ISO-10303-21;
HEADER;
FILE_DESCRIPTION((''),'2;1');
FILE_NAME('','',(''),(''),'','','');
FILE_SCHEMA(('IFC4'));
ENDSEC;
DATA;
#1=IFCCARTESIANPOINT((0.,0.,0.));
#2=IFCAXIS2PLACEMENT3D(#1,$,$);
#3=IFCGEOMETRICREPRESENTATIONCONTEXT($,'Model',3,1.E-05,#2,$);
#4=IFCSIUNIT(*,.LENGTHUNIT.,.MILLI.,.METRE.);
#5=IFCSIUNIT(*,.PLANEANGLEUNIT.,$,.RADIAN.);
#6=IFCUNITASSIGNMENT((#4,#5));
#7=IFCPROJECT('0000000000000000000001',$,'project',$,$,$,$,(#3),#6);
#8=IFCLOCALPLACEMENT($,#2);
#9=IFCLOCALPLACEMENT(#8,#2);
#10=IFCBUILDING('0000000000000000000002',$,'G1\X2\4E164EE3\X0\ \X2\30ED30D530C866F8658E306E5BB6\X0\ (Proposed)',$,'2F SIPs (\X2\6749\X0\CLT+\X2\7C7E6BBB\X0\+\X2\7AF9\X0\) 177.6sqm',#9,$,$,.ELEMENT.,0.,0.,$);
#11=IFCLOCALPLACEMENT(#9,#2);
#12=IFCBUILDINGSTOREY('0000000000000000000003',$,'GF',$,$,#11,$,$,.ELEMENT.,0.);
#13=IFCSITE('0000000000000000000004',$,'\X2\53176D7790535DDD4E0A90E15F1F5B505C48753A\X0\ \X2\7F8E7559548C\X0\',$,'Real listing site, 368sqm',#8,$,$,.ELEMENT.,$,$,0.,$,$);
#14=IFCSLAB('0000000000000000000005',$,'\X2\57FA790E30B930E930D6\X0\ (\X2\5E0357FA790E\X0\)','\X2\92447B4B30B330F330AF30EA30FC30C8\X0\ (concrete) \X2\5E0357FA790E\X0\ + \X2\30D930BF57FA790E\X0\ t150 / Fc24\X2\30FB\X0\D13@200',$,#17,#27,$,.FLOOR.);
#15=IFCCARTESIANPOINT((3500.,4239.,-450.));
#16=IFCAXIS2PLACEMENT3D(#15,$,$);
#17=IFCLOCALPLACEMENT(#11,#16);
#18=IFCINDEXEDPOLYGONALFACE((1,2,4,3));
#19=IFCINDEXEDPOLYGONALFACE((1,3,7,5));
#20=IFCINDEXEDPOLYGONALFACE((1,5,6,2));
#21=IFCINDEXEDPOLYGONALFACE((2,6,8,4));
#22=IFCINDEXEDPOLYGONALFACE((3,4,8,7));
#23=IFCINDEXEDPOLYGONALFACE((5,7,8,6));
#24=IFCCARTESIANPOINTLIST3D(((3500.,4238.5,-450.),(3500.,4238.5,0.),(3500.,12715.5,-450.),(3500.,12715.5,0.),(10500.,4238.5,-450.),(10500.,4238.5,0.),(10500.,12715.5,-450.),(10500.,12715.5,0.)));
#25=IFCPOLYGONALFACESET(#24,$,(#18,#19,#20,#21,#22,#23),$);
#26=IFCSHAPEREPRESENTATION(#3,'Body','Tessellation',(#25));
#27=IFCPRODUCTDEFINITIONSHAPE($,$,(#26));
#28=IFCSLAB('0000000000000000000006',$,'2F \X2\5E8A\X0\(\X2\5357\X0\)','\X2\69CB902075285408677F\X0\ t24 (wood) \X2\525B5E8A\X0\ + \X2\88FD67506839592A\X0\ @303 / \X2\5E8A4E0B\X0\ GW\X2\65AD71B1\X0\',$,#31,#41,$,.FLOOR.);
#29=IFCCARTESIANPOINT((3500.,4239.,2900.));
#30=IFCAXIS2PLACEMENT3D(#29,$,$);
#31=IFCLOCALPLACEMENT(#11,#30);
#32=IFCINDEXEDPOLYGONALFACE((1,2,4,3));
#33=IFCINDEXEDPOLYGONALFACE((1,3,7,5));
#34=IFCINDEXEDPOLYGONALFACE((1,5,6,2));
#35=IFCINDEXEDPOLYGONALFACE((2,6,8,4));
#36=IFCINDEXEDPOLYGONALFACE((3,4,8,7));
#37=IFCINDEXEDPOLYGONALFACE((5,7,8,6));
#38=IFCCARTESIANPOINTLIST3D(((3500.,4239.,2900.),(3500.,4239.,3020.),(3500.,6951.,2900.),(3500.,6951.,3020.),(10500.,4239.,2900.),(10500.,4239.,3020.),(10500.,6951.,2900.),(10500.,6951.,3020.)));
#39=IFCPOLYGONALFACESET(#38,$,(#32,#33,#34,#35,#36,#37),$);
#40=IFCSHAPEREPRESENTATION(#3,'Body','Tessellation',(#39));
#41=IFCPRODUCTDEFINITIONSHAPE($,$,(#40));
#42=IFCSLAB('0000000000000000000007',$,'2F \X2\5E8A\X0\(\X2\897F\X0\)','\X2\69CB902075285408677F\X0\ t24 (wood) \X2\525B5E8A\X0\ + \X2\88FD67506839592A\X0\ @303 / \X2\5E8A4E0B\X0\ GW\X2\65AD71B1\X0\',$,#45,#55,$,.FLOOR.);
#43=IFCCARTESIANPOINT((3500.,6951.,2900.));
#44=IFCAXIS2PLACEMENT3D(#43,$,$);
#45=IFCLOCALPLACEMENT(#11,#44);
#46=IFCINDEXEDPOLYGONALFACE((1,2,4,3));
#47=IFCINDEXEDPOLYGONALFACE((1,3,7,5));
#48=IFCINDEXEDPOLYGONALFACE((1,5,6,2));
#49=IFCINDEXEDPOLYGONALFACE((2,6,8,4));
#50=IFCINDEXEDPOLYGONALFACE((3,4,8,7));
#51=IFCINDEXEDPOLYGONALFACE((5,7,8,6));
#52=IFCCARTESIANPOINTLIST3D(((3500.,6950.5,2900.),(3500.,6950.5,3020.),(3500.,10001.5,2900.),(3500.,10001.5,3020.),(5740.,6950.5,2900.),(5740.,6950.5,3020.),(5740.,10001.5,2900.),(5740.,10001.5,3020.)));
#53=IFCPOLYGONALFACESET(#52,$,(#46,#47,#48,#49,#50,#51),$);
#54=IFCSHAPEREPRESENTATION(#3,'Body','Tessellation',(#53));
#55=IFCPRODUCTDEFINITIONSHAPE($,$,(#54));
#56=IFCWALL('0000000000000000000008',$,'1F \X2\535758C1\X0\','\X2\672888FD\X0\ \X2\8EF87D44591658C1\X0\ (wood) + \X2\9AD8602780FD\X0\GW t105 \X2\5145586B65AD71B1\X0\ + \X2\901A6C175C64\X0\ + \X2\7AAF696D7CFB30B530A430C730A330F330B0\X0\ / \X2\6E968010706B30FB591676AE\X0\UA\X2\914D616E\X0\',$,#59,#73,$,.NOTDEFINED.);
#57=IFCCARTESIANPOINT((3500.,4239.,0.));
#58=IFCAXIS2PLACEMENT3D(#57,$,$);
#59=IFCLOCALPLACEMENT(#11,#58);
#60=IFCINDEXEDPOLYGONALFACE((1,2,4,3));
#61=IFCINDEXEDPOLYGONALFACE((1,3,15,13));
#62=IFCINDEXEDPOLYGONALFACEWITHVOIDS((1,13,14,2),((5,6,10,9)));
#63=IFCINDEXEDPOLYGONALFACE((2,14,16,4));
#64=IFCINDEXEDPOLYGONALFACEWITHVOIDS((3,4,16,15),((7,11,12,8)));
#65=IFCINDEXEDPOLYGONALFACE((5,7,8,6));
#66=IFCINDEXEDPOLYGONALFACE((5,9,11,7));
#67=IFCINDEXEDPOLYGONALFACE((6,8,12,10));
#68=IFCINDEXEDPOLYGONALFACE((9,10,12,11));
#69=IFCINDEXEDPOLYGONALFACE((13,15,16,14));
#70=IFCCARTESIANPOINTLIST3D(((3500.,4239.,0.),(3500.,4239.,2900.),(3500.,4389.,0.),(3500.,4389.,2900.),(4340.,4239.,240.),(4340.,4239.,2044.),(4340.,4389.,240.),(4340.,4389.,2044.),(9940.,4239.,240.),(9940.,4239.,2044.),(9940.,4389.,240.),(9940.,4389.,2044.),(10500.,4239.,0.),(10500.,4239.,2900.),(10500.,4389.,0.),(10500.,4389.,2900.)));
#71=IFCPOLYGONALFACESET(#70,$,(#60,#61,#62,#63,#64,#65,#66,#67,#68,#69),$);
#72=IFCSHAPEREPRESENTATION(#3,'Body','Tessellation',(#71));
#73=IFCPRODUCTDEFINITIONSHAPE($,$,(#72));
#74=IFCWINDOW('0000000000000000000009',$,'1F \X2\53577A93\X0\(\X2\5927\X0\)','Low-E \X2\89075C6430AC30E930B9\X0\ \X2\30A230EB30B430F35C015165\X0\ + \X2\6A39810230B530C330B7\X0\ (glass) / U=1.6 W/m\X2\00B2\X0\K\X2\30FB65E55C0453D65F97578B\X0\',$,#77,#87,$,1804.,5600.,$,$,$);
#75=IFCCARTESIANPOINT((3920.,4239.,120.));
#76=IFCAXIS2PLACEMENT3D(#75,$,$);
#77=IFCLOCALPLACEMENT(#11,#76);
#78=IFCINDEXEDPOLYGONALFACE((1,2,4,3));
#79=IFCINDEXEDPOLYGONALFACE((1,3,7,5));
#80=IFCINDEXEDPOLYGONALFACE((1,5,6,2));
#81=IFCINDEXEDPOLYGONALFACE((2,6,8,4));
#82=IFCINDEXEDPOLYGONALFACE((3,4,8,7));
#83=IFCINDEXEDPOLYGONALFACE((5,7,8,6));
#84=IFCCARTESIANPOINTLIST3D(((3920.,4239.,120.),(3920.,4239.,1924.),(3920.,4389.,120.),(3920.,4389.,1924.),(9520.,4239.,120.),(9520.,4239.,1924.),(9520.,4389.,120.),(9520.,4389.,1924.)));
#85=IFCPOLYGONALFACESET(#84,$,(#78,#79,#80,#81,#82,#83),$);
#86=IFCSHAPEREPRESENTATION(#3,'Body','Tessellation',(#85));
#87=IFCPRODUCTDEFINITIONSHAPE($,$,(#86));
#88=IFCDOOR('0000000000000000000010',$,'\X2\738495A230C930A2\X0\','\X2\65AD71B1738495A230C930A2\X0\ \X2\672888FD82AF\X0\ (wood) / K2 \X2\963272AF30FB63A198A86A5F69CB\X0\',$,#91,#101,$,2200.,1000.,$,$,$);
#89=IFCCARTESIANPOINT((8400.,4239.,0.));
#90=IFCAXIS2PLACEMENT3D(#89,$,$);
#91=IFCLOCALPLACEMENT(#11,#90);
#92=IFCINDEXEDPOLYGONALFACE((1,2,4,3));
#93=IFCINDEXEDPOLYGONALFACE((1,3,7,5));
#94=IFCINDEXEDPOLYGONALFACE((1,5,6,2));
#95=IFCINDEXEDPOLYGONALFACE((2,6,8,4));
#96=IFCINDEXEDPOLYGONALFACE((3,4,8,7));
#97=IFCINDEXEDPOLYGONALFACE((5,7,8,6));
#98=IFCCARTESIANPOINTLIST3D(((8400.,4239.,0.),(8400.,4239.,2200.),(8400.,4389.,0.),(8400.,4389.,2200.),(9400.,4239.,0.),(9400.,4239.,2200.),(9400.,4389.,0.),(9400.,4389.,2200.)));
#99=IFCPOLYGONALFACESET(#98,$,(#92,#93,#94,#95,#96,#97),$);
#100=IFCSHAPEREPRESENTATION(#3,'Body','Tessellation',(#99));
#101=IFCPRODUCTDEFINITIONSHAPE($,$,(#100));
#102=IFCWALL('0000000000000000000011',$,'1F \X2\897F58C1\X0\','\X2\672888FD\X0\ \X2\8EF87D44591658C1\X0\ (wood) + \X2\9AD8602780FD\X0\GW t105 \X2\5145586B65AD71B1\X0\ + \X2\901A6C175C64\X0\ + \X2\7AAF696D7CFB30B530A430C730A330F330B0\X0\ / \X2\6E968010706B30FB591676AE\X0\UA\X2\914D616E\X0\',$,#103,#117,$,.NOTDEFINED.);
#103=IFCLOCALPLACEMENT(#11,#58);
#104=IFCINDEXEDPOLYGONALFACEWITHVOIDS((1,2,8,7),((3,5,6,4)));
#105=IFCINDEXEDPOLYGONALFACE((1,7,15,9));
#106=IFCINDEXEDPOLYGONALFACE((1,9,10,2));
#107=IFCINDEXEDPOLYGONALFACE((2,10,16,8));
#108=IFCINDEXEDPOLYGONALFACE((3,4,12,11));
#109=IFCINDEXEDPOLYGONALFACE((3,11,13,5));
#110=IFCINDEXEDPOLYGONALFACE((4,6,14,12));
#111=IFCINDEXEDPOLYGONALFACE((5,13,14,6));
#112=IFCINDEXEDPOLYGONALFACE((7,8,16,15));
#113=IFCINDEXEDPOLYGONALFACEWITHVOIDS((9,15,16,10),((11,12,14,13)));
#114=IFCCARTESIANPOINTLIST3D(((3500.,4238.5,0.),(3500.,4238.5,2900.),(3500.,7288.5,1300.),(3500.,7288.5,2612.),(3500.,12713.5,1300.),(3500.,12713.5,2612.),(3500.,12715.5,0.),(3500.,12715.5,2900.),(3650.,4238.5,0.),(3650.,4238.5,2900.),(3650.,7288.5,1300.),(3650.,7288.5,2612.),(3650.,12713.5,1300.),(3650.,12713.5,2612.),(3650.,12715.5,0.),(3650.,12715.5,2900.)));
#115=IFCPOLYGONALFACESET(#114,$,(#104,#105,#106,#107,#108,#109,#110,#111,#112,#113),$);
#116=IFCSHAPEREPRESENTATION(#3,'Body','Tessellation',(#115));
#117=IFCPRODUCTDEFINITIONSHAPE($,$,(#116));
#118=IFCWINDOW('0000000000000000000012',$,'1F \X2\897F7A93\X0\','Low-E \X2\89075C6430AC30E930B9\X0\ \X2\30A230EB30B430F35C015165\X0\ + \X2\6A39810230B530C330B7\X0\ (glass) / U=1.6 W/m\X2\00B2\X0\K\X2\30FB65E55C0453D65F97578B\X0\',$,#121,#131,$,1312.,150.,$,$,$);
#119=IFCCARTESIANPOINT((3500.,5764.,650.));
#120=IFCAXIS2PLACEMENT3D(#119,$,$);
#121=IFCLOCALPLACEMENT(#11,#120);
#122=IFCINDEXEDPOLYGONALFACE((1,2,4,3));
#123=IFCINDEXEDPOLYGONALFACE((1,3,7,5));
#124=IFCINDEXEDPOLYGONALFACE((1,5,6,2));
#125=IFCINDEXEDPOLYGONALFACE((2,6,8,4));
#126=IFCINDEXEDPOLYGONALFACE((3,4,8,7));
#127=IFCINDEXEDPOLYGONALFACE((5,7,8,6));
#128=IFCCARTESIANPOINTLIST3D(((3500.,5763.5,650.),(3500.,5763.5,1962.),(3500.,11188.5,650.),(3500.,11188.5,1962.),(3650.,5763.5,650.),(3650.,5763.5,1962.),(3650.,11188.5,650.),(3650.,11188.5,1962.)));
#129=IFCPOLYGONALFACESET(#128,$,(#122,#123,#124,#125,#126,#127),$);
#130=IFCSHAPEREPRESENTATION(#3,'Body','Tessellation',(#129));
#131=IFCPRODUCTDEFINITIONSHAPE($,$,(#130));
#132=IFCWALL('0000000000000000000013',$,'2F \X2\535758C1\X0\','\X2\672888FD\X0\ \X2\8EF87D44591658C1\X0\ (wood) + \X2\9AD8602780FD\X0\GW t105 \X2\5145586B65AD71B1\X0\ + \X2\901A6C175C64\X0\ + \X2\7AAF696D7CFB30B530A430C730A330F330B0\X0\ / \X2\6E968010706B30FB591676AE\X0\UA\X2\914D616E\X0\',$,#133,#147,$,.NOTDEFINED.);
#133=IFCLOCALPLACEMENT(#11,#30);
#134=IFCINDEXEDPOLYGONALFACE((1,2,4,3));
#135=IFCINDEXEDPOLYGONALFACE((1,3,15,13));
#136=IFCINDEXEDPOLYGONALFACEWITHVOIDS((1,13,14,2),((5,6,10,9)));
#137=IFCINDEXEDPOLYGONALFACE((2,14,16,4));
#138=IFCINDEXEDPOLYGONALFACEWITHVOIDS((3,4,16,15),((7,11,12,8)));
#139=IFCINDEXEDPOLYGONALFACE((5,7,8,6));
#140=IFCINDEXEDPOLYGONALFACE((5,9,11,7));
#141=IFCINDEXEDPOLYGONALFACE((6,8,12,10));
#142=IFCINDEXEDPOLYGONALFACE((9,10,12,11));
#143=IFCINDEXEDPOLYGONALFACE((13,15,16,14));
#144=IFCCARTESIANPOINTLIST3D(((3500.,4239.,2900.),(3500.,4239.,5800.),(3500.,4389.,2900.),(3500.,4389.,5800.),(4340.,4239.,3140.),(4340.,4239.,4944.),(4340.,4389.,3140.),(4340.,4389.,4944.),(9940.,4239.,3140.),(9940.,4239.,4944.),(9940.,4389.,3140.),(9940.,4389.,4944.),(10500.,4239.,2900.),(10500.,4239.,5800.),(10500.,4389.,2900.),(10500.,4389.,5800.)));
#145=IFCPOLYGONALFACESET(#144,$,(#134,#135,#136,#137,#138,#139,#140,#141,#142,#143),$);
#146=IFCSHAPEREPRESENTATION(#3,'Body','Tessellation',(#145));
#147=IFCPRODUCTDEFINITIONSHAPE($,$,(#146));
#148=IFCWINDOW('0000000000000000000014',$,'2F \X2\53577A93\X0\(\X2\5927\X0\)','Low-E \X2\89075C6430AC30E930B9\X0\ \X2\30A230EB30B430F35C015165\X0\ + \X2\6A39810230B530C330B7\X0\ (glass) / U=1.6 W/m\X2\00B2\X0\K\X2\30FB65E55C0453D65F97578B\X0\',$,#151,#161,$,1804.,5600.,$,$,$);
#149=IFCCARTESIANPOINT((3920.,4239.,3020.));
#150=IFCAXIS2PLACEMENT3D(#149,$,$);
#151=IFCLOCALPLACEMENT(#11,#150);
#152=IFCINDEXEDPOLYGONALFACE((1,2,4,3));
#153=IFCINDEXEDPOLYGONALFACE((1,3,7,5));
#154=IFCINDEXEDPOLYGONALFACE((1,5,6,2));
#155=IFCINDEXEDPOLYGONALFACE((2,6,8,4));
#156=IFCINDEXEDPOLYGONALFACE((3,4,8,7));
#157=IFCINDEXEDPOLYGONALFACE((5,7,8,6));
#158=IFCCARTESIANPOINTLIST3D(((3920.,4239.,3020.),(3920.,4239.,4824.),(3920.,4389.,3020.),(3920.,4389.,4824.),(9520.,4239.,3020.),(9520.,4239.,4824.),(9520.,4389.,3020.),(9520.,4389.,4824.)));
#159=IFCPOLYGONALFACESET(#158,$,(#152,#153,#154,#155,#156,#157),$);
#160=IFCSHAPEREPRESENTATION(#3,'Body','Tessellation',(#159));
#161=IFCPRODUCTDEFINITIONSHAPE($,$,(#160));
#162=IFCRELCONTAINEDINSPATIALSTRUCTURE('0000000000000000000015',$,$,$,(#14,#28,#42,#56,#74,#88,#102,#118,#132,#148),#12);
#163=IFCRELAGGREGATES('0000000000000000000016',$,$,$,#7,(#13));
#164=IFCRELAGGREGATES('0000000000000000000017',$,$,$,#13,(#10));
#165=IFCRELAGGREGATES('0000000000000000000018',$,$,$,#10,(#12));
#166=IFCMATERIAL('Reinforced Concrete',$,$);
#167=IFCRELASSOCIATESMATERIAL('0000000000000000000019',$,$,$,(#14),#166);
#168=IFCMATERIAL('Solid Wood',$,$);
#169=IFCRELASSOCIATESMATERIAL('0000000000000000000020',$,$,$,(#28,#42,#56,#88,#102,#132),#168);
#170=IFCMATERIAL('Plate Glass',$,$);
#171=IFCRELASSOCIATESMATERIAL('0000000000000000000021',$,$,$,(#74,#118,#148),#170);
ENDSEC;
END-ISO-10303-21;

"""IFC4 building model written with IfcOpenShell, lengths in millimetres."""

from ifc_helpers import new_model, si_unit, frame, frame_2d, origin, place, context, project, spatial, rectangle, extrude, material, element, fill, save


model = new_model("IFC4")

# Units and contexts
model_context = context("Model", 3, precision=1e-05, world=origin())
ifc_project = project(units=[si_unit("LENGTHUNIT", "METRE", prefix="MILLI"), si_unit("PLANEANGLEUNIT", "RADIAN")], contexts=[model_context])

# Site, building, storey
site_placement = place(None, origin())
site = spatial("IfcSite", under=ifc_project, at=site_placement, Name="北海道川上郡弟子屈町 美留和", ObjectType="Real listing site, 368sqm", CompositionType="ELEMENT", RefElevation=0.0)
building_placement = place(site_placement, origin())
building = spatial("IfcBuilding", under=site, at=building_placement, Name="G1世代 ロフト書斎の家 (Proposed)", ObjectType="2F SIPs (杉CLT+籾殻+竹) 177.6sqm", CompositionType="ELEMENT", ElevationOfRefHeight=0.0, ElevationOfTerrain=0.0)
storey_placement = place(building_placement, origin())
storey = spatial("IfcBuildingStorey", under=building, at=storey_placement, Name="GF", CompositionType="ELEMENT", Elevation=0.0)

# Slabs
ifc_material_1 = material(Name="Reinforced Concrete")
slab_1_placement = place(storey_placement, frame((3500.0, 4239.0, -450.0)))
element("IfcSlab", 1, at=slab_1_placement, inside=storey, material=ifc_material_1, Name="基礎スラブ (布基礎)", Description="鉄筋コンクリート (concrete) 布基礎 + ベタ基礎 t150 / Fc24・D13@200", PredefinedType="FLOOR", context=model_context, shape_type="SweptSolid", body=[
    extrude(rectangle(XDim=7000.0, YDim=8477.0, at=frame_2d((3500.0, 4238.0))), frame((3500.0, 4239.0, -450.0)), (0.0, 0.0, 1.0), 450.0),
])
ifc_material_2 = material(Name="Solid Wood")
slab_2_placement = place(storey_placement, frame((3500.0, 4239.0, 2900.0)))
element("IfcSlab", 2, at=slab_2_placement, inside=storey, material=ifc_material_2, Name="2F 床(南)", Description="構造用合板 t24 (wood) 剛床 + 製材根太 @303 / 床下 GW断熱", PredefinedType="FLOOR", context=model_context, shape_type="SweptSolid", body=[
    extrude(rectangle(XDim=7000.0, YDim=2712.0, at=frame_2d((3500.0, 1356.0))), frame((3500.0, 4239.0, 2900.0)), (0.0, 0.0, 1.0), 120.0),
])
slab_3_placement = place(storey_placement, frame((3500.0, 6951.0, 2900.0)))
element("IfcSlab", 3, at=slab_3_placement, inside=storey, material=ifc_material_2, Name="2F 床(西)", Description="構造用合板 t24 (wood) 剛床 + 製材根太 @303 / 床下 GW断熱", PredefinedType="FLOOR", context=model_context, shape_type="SweptSolid", body=[
    extrude(rectangle(XDim=2240.0, YDim=3051.0, at=frame_2d((1120.0, 1525.0))), frame((3500.0, 6951.0, 2900.0)), (0.0, 0.0, 1.0), 120.0),
])

# Wall, openings, window, door
wall_1_placement = place(storey_placement, frame((3500.0, 4239.0, 0.0)))
wall_1 = element("IfcWall", 4, at=wall_1_placement, inside=storey, material=ifc_material_2, Name="1F 南壁", Description="木製 軸組外壁 (wood) + 高性能GW t105 充填断熱 + 通気層 + 窯業系サイディング / 準耐火・外皮UA配慮", PredefinedType="NOTDEFINED", context=model_context, shape_type="SweptSolid", body=[
    extrude(rectangle(XDim=7000.0, YDim=150.0, at=frame_2d((3500.0, 75.0))), frame((3500.0, 4239.0, 0.0)), (0.0, 0.0, 1.0), 2900.0),
])
opening_1_placement = place(storey_placement, frame((3920.0, 4239.0, 120.0)))
opening_1 = element("IfcOpeningElement", 5, at=opening_1_placement, cuts=wall_1, PredefinedType="NOTDEFINED", context=model_context, shape_type="SweptSolid", body=[
    extrude(rectangle(XDim=5600.0, YDim=150.0, at=frame_2d((2800.0, 75.0))), frame((3920.0, 4239.0, 120.0)), (0.0, 0.0, 1.0), 1804.0),
])
opening_2_placement = place(storey_placement, frame((8400.0, 4239.0, 0.0)))
opening_2 = element("IfcOpeningElement", 6, at=opening_2_placement, cuts=wall_1, PredefinedType="NOTDEFINED", context=model_context, shape_type="SweptSolid", body=[
    extrude(rectangle(XDim=1000.0, YDim=150.0, at=frame_2d((500.0, 75.0))), frame((8400.0, 4239.0, 0.0)), (0.0, 0.0, 1.0), 2200.0),
])
ifc_material_3 = material(Name="Plate Glass")
window_1_placement = place(storey_placement, frame((3920.0, 4239.0, 120.0)))
window_1 = element("IfcWindow", 7, at=window_1_placement, inside=storey, material=ifc_material_3, Name="1F 南窓(大)", Description="Low-E 複層ガラス アルゴン封入 + 樹脂サッシ (glass) / U=1.6 W/m²K・日射取得型", OverallHeight=1804.0, OverallWidth=5600.0, context=model_context, shape_type="SweptSolid", body=[
    extrude(rectangle(XDim=5600.0, YDim=150.0, at=frame_2d((2800.0, 75.0))), frame((3920.0, 4239.0, 120.0)), (0.0, 0.0, 1.0), 1804.0),
])
fill(opening_1, window_1)
door_placement = place(storey_placement, frame((8400.0, 4239.0, 0.0)))
door = element("IfcDoor", 8, at=door_placement, inside=storey, material=ifc_material_2, Name="玄関ドア", Description="断熱玄関ドア 木製芯 (wood) / K2 防犯・採風機構", OverallHeight=2200.0, OverallWidth=1000.0, context=model_context, shape_type="SweptSolid", body=[
    extrude(rectangle(XDim=1000.0, YDim=150.0, at=frame_2d((500.0, 75.0))), frame((8400.0, 4239.0, 0.0)), (0.0, 0.0, 1.0), 2200.0),
])
fill(opening_2, door)

# Walls, openings, windows
wall_2_placement = place(storey_placement, frame((3500.0, 4239.0, 0.0)))
wall_2 = element("IfcWall", 9, at=wall_2_placement, inside=storey, material=ifc_material_2, Name="1F 西壁", Description="木製 軸組外壁 (wood) + 高性能GW t105 充填断熱 + 通気層 + 窯業系サイディング / 準耐火・外皮UA配慮", PredefinedType="NOTDEFINED", context=model_context, shape_type="SweptSolid", body=[
    extrude(rectangle(XDim=150.0, YDim=8477.0, at=frame_2d((75.0, 4238.0))), frame((3500.0, 4239.0, 0.0)), (0.0, 0.0, 1.0), 2900.0),
])
opening_3_placement = place(storey_placement, frame((3500.0, 5764.0, 650.0)))
opening_3 = element("IfcOpeningElement", 10, at=opening_3_placement, cuts=wall_2, PredefinedType="NOTDEFINED", context=model_context, shape_type="SweptSolid", body=[
    extrude(rectangle(XDim=150.0, YDim=5425.0, at=frame_2d((75.0, 2712.0))), frame((3500.0, 5764.0, 650.0)), (0.0, 0.0, 1.0), 1312.0),
])
window_2_placement = place(storey_placement, frame((3500.0, 5764.0, 650.0)))
window_2 = element("IfcWindow", 11, at=window_2_placement, inside=storey, material=ifc_material_3, Name="1F 西窓", Description="Low-E 複層ガラス アルゴン封入 + 樹脂サッシ (glass) / U=1.6 W/m²K・日射取得型", OverallHeight=1312.0, OverallWidth=150.0, context=model_context, shape_type="SweptSolid", body=[
    extrude(rectangle(XDim=150.0, YDim=5425.0, at=frame_2d((75.0, 2712.0))), frame((3500.0, 5764.0, 650.0)), (0.0, 0.0, 1.0), 1312.0),
])
fill(opening_3, window_2)
wall_3_placement = place(storey_placement, frame((3500.0, 4239.0, 2900.0)))
wall_3 = element("IfcWall", 12, at=wall_3_placement, inside=storey, material=ifc_material_2, Name="2F 南壁", Description="木製 軸組外壁 (wood) + 高性能GW t105 充填断熱 + 通気層 + 窯業系サイディング / 準耐火・外皮UA配慮", PredefinedType="NOTDEFINED", context=model_context, shape_type="SweptSolid", body=[
    extrude(rectangle(XDim=7000.0, YDim=150.0, at=frame_2d((3500.0, 75.0))), frame((3500.0, 4239.0, 2900.0)), (0.0, 0.0, 1.0), 2900.0),
])
opening_4_placement = place(storey_placement, frame((3920.0, 4239.0, 3020.0)))
opening_4 = element("IfcOpeningElement", 13, at=opening_4_placement, cuts=wall_3, PredefinedType="NOTDEFINED", context=model_context, shape_type="SweptSolid", body=[
    extrude(rectangle(XDim=5600.0, YDim=150.0, at=frame_2d((2800.0, 75.0))), frame((3920.0, 4239.0, 3020.0)), (0.0, 0.0, 1.0), 1804.0),
])
window_3_placement = place(storey_placement, frame((3920.0, 4239.0, 3020.0)))
window_3 = element("IfcWindow", 14, at=window_3_placement, inside=storey, material=ifc_material_3, Name="2F 南窓(大)", Description="Low-E 複層ガラス アルゴン封入 + 樹脂サッシ (glass) / U=1.6 W/m²K・日射取得型", OverallHeight=1804.0, OverallWidth=5600.0, context=model_context, shape_type="SweptSolid", body=[
    extrude(rectangle(XDim=5600.0, YDim=150.0, at=frame_2d((2800.0, 75.0))), frame((3920.0, 4239.0, 3020.0)), (0.0, 0.0, 1.0), 1804.0),
])
fill(opening_4, window_3)

save(model, "model.ifc")
